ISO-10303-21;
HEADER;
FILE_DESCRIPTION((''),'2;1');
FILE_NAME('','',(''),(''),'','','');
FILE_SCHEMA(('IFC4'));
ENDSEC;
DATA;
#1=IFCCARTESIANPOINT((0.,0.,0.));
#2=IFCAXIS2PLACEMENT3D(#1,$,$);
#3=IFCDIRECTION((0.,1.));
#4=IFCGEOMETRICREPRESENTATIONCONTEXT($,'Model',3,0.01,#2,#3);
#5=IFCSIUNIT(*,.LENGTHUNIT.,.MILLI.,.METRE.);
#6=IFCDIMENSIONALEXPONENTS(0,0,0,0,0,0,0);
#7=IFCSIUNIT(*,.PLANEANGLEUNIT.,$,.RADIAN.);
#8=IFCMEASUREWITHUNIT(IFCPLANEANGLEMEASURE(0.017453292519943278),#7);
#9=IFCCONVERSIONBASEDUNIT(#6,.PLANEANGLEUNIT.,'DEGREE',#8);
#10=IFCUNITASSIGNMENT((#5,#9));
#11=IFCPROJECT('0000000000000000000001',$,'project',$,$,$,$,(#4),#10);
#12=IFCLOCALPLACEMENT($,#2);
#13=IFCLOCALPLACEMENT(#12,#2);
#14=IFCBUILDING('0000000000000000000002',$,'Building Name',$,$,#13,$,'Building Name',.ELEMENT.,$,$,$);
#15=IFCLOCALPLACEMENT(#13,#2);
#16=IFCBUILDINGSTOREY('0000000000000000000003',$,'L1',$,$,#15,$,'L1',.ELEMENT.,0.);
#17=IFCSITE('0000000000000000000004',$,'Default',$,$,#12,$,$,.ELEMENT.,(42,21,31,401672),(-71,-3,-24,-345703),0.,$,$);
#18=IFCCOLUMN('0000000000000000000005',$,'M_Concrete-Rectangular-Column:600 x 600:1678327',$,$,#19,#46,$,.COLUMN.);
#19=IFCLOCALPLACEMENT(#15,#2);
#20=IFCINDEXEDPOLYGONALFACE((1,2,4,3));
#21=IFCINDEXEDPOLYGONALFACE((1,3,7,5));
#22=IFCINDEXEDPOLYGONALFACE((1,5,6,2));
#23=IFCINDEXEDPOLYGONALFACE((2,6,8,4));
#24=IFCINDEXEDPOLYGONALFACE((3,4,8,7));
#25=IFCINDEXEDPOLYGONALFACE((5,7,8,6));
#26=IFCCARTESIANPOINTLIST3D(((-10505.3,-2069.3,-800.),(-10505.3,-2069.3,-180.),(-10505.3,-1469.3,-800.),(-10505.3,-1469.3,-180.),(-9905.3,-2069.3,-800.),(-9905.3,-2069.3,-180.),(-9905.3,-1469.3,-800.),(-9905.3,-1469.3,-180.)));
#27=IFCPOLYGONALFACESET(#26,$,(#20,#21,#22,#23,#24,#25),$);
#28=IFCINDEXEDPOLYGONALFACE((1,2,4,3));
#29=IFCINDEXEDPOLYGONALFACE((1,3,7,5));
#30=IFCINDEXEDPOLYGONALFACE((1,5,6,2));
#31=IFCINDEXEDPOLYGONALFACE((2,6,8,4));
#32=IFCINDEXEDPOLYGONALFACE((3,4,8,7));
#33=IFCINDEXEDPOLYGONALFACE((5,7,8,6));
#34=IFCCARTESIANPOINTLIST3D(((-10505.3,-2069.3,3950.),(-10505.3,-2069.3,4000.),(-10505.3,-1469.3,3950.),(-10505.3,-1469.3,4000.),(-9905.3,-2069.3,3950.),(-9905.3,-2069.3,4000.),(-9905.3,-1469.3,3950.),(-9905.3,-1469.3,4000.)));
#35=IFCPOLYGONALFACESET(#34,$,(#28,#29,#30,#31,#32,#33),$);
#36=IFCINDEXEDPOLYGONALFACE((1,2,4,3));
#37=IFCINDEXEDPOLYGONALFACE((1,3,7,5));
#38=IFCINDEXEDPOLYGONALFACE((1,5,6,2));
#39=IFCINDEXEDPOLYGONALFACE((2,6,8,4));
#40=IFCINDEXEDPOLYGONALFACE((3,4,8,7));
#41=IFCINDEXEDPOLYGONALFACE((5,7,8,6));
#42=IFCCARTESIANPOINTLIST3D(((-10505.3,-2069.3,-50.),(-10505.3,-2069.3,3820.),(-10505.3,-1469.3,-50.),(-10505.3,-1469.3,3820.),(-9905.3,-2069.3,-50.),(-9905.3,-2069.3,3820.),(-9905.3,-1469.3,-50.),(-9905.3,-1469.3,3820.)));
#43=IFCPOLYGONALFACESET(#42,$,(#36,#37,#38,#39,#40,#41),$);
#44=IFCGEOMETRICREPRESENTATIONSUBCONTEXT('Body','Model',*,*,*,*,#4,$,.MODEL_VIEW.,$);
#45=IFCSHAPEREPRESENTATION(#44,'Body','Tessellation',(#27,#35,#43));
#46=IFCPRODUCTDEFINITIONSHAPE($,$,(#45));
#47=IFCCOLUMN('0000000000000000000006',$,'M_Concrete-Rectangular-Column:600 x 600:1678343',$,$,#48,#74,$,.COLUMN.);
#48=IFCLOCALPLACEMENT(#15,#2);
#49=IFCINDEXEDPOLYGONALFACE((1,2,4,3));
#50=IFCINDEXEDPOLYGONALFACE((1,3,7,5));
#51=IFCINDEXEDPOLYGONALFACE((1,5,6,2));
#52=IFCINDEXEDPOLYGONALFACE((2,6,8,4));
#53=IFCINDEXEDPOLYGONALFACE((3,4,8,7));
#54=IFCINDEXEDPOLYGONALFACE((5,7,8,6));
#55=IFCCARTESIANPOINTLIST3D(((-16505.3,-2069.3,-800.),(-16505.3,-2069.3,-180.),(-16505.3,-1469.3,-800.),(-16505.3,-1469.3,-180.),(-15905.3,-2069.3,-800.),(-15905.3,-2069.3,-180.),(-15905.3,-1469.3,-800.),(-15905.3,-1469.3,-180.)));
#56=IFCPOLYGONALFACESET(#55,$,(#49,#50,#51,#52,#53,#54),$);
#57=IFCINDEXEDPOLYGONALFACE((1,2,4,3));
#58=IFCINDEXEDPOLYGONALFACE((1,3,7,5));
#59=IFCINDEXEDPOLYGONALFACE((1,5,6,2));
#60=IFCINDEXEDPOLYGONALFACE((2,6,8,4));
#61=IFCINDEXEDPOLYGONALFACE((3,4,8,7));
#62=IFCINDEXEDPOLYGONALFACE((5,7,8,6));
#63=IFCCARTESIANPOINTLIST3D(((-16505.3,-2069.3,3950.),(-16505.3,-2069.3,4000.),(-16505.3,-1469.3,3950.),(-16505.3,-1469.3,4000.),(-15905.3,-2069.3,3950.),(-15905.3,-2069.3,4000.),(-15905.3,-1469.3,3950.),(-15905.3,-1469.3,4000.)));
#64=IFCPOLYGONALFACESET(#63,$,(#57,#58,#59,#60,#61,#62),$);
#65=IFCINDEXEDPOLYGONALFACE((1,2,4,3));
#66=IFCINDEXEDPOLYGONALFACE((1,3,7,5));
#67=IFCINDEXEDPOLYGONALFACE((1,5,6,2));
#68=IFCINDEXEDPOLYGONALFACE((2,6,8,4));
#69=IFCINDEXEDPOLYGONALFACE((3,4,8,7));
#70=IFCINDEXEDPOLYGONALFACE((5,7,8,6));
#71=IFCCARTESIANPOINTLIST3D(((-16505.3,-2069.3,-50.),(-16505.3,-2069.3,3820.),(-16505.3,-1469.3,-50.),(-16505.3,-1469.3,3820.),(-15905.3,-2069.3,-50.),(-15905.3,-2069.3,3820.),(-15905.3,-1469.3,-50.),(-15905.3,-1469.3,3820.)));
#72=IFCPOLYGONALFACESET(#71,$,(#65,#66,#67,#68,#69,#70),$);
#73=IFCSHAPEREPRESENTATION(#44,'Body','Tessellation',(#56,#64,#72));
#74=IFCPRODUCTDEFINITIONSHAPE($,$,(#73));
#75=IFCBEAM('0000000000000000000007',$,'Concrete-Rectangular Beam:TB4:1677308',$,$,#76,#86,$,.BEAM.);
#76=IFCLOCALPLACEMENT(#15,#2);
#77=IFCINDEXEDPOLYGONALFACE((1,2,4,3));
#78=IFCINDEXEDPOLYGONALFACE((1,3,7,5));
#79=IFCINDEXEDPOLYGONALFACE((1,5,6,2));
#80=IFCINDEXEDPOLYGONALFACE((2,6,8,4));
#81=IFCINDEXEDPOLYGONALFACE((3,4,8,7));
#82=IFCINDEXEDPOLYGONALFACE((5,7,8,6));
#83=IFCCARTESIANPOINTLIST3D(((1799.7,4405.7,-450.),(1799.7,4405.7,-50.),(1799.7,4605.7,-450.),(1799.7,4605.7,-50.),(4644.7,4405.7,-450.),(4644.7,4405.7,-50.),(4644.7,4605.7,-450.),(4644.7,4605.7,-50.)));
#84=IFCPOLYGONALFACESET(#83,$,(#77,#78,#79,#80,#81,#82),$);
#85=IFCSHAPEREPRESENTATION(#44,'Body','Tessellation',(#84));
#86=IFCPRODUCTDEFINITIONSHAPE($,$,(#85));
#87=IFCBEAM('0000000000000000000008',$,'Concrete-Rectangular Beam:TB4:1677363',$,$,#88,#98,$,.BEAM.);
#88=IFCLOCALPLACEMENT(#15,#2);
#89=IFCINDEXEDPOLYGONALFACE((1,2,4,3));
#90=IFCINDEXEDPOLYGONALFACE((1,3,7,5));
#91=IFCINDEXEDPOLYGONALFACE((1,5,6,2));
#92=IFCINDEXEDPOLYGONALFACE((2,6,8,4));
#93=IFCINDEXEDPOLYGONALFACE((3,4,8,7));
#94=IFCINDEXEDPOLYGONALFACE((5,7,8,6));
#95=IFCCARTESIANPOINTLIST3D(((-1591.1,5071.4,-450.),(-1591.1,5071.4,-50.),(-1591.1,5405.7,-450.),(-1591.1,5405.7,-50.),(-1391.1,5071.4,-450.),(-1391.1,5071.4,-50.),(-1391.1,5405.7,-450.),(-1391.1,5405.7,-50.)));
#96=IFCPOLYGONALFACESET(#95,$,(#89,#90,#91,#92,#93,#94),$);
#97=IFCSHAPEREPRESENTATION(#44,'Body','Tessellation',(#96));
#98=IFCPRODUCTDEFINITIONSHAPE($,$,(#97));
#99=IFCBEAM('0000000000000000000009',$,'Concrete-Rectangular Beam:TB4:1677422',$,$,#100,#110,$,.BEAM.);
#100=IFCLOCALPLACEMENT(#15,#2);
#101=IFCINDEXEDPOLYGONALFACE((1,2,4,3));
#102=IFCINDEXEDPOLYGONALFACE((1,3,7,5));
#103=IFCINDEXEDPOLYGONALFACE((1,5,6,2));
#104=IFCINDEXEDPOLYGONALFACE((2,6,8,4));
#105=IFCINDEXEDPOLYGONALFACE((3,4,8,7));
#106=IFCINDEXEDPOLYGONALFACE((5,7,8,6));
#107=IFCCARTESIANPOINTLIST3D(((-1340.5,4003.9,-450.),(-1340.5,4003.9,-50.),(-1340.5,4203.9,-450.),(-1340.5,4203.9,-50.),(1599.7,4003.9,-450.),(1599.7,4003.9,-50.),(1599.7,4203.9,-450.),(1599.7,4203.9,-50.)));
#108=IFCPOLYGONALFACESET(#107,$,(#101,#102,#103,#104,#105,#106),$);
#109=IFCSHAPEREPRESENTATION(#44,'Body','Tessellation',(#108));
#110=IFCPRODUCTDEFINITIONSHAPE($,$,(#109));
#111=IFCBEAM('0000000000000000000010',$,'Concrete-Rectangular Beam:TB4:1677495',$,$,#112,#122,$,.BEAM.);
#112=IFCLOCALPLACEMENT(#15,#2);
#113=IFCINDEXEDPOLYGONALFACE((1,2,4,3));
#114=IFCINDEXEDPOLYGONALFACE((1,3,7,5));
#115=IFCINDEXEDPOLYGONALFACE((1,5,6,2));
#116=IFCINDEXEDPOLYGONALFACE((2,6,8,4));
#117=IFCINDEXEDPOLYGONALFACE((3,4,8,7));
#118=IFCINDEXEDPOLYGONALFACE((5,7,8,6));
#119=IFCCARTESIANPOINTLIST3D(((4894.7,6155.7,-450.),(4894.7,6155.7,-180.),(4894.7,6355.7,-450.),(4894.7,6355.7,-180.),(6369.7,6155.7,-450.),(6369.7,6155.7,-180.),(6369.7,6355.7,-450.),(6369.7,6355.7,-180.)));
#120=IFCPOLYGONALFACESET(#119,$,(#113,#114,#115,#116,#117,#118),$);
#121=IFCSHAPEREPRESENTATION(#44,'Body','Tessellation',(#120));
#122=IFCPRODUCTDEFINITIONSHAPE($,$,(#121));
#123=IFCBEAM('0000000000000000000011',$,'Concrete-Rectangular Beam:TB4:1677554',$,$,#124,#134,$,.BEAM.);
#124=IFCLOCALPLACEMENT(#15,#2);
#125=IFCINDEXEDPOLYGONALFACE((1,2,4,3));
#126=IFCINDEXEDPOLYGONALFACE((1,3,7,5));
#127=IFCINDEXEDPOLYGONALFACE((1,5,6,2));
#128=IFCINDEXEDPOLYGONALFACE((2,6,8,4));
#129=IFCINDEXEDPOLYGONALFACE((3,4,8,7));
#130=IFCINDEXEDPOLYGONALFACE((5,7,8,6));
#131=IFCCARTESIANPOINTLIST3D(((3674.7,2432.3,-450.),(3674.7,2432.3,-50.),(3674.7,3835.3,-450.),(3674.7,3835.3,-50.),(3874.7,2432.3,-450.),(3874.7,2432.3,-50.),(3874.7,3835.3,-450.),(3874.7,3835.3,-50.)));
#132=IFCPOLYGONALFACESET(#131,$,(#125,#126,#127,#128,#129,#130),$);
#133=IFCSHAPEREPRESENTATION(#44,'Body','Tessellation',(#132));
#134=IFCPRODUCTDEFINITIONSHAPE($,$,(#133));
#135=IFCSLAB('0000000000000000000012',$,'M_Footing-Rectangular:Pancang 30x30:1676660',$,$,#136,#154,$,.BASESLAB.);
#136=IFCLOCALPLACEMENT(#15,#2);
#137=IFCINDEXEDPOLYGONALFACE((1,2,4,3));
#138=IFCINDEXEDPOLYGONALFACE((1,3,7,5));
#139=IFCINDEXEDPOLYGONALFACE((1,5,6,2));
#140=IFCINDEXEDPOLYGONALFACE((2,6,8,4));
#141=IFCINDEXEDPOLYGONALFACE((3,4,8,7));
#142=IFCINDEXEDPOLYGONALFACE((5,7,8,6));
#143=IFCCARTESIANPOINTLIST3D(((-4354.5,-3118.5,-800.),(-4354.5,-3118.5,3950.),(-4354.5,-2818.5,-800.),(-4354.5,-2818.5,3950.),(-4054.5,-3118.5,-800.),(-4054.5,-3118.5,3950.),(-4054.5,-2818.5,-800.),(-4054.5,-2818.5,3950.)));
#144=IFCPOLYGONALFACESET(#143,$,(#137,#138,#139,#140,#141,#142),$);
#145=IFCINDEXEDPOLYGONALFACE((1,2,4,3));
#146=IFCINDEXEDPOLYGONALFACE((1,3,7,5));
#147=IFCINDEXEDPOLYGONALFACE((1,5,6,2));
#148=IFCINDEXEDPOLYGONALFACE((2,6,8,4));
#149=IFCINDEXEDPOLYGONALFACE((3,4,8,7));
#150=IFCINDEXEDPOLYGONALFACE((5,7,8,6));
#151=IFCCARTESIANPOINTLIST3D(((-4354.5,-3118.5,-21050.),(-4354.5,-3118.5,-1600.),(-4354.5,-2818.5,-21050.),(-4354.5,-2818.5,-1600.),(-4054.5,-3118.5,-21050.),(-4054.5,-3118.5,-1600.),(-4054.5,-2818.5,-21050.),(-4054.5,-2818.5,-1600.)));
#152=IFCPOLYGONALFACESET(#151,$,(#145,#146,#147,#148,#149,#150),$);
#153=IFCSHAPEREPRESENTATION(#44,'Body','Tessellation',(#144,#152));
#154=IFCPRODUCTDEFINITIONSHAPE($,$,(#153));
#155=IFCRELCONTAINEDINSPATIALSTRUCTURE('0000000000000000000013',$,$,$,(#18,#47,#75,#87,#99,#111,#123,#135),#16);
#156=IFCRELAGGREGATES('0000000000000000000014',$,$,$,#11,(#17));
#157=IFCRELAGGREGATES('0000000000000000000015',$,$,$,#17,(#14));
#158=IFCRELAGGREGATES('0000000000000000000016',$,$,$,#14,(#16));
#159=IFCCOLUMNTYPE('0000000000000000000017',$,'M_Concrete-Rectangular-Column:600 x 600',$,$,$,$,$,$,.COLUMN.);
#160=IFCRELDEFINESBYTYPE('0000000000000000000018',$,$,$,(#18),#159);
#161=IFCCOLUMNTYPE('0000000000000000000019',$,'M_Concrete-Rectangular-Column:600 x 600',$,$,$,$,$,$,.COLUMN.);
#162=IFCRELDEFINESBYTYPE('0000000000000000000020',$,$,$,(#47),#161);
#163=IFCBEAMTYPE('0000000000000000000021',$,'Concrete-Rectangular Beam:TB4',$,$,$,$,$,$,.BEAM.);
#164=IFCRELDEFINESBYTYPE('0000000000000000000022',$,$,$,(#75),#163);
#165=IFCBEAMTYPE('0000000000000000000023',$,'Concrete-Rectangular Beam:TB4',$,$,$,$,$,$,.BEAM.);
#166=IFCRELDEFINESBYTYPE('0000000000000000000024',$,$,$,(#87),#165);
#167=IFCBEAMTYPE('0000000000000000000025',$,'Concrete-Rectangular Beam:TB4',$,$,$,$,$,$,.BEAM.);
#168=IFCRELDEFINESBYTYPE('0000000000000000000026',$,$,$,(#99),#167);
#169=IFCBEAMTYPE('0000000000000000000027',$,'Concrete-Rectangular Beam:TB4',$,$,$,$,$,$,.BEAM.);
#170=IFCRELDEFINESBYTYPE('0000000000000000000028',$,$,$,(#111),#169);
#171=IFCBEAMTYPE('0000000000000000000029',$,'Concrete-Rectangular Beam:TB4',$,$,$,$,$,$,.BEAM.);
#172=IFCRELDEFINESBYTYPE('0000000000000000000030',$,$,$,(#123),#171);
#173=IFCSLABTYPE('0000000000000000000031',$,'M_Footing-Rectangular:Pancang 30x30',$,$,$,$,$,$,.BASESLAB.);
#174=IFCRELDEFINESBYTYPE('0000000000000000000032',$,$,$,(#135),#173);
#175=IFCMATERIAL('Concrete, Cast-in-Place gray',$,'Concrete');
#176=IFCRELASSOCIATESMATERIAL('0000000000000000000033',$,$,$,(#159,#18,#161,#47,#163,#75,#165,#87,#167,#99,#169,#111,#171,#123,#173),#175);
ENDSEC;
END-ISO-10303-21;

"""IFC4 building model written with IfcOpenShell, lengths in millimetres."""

from ifc_helpers import new_model, entity, si_unit, converted_unit, direction, frame, origin, place, context, subcontext, project, spatial, indexed_curve, outline, extrude, source, transform, mapped, material, type_object, type_shapes, element, save


model = new_model("IFC4")

# Units and contexts
model_context = context("Model", 3, precision=0.01, world=origin(), true_north=direction((0.0, 1.0)))
body_context = subcontext(model_context, "Body", "Model", "MODEL_VIEW")
ifc_project = project(units=[si_unit("LENGTHUNIT", "METRE", prefix="MILLI"), converted_unit("PLANEANGLEUNIT", "DEGREE", entity("IfcPlaneAngleMeasure", 0.017453292519943278), si_unit("PLANEANGLEUNIT", "RADIAN"), dimensions=[0, 0, 0, 0, 0, 0, 0])], contexts=[model_context])

# Site, building, storey
site_placement = place(None, origin())
site = spatial("IfcSite", under=ifc_project, at=site_placement, Name="Default", CompositionType="ELEMENT", RefLatitude=(42, 21, 31, 401672), RefLongitude=(-71, -3, -24, -345703), RefElevation=0.0)
building_placement = place(site_placement, origin())
building = spatial("IfcBuilding", under=site, at=building_placement, Name="Building Name", LongName="Building Name", CompositionType="ELEMENT")
storey_placement = place(building_placement, origin())
storey = spatial("IfcBuildingStorey", under=building, at=storey_placement, Name="L1", LongName="L1", CompositionType="ELEMENT", Elevation=0.0)

# Columns
ifc_material = material(Name="Concrete, Cast-in-Place gray", Category="Concrete")
column_type_1 = type_object("IfcColumnType", Name="M_Concrete-Rectangular-Column:600 x 600", PredefinedType="COLUMN", material=ifc_material)
shared_shape_1 = source(origin(), body_context, "Body", "SweptSolid", [
    extrude(outline(indexed_curve([(-300.0, -300.0), (300.0, -300.0), (300.0, 300.0), (-300.0, 300.0), (-300.0, -300.0)], self_intersect=False)), frame((-10205.3, -1769.3, -800.0), z_axis=(0.0, 0.0, 1.0), x_axis=(-1.0, 0.0, 0.0)), (0.0, 0.0, 1.0), 620.0),
    extrude(outline(indexed_curve([(-300.0, -300.0), (300.0, -300.0), (300.0, 300.0), (-300.0, 300.0), (-300.0, -300.0)], self_intersect=False)), frame((-10205.3, -1769.3, 3950.0)), (0.0, 0.0, 1.0), 50.0),
    extrude(outline(indexed_curve([(-300.0, -300.0), (300.0, -300.0), (300.0, 300.0), (-300.0, 300.0), (-300.0, -300.0)], self_intersect=False)), frame((-10205.3, -1769.3, -50.0), z_axis=(0.0, 0.0, 1.0), x_axis=(0.0, 1.0, 0.0)), (0.0, 0.0, 1.0), 3870.0),
])
type_shapes(column_type_1, [shared_shape_1])
column_1_placement = place(storey_placement, origin())
element("IfcColumn", 1, at=column_1_placement, inside=storey, type_object=column_type_1, material=ifc_material, Name="M_Concrete-Rectangular-Column:600 x 600:1678327", PredefinedType="COLUMN", context=body_context, shape_type="MappedRepresentation", body=[
    mapped(shared_shape_1, transform((0.0, 0.0, 0.0), scale=1.0)),
])
column_type_2 = type_object("IfcColumnType", Name="M_Concrete-Rectangular-Column:600 x 600", PredefinedType="COLUMN", material=ifc_material)
shared_shape_2 = source(origin(), body_context, "Body", "SweptSolid", [
    extrude(outline(indexed_curve([(-300.0, -300.0), (300.0, -300.0), (300.0, 300.0), (-300.0, 300.0), (-300.0, -300.0)], self_intersect=False)), frame((-16205.3, -1769.3, -800.0), z_axis=(0.0, 0.0, 1.0), x_axis=(-1.0, 0.0, 0.0)), (0.0, 0.0, 1.0), 620.0),
    extrude(outline(indexed_curve([(-300.0, -300.0), (300.0, -300.0), (300.0, 300.0), (-300.0, 300.0), (-300.0, -300.0)], self_intersect=False)), frame((-16205.3, -1769.3, 3950.0), z_axis=(0.0, 0.0, 1.0), x_axis=(0.0, 1.0, 0.0)), (0.0, 0.0, 1.0), 50.0),
    extrude(outline(indexed_curve([(-300.0, -300.0), (300.0, -300.0), (300.0, 300.0), (-300.0, 300.0), (-300.0, -300.0)], self_intersect=False)), frame((-16205.3, -1769.3, -50.0), z_axis=(0.0, 0.0, 1.0), x_axis=(0.0, 1.0, 0.0)), (0.0, 0.0, 1.0), 3870.0),
])
type_shapes(column_type_2, [shared_shape_2])
column_2_placement = place(storey_placement, origin())
element("IfcColumn", 2, at=column_2_placement, inside=storey, type_object=column_type_2, material=ifc_material, Name="M_Concrete-Rectangular-Column:600 x 600:1678343", PredefinedType="COLUMN", context=body_context, shape_type="MappedRepresentation", body=[
    mapped(shared_shape_2, transform((0.0, 0.0, 0.0), scale=1.0)),
])

# Beams
beam_type_1 = type_object("IfcBeamType", Name="Concrete-Rectangular Beam:TB4", PredefinedType="BEAM", material=ifc_material)
shared_shape_3 = source(origin(), body_context, "Body", "SweptSolid", [
    extrude(outline(indexed_curve([(-200.0, -100.0), (200.0, -100.0), (200.0, 100.0), (-200.0, 100.0), (-200.0, -100.0)], self_intersect=False)), frame((1799.7, 4505.7, -250.0), z_axis=(1.0, 0.0, 0.0), x_axis=(0.0, 0.0, -1.0)), (0.0, 0.0, 1.0), 2845.0),
])
type_shapes(beam_type_1, [shared_shape_3])
beam_1_placement = place(storey_placement, origin())
element("IfcBeam", 3, at=beam_1_placement, inside=storey, type_object=beam_type_1, material=ifc_material, Name="Concrete-Rectangular Beam:TB4:1677308", PredefinedType="BEAM", context=body_context, shape_type="MappedRepresentation", body=[
    mapped(shared_shape_3, transform((0.0, 0.0, 0.0), scale=1.0)),
])
beam_type_2 = type_object("IfcBeamType", Name="Concrete-Rectangular Beam:TB4", PredefinedType="BEAM", material=ifc_material)
shared_shape_4 = source(origin(), body_context, "Body", "SweptSolid", [
    extrude(outline(indexed_curve([(-100.0, -200.0), (100.0, -200.0), (100.0, 200.0), (-100.0, 200.0), (-100.0, -200.0)], self_intersect=False)), frame((-1491.1, 5405.7, -250.0), z_axis=(0.0, -1.0, 0.0), x_axis=(-1.0, 0.0, 0.0)), (0.0, 0.0, 1.0), 334.2),
])
type_shapes(beam_type_2, [shared_shape_4])
beam_2_placement = place(storey_placement, origin())
element("IfcBeam", 4, at=beam_2_placement, inside=storey, type_object=beam_type_2, material=ifc_material, Name="Concrete-Rectangular Beam:TB4:1677363", PredefinedType="BEAM", context=body_context, shape_type="MappedRepresentation", body=[
    mapped(shared_shape_4, transform((0.0, 0.0, 0.0), scale=1.0)),
])
beam_type_3 = type_object("IfcBeamType", Name="Concrete-Rectangular Beam:TB4", PredefinedType="BEAM", material=ifc_material)
shared_shape_5 = source(origin(), body_context, "Body", "SweptSolid", [
    extrude(outline(indexed_curve([(-200.0, -100.0), (200.0, -100.0), (200.0, 100.0), (-200.0, 100.0), (-200.0, -100.0)], self_intersect=False)), frame((-1340.5, 4103.9, -250.0), z_axis=(1.0, 0.0, 0.0), x_axis=(0.0, 0.0, -1.0)), (0.0, 0.0, 1.0), 2940.2),
])
type_shapes(beam_type_3, [shared_shape_5])
beam_3_placement = place(storey_placement, origin())
element("IfcBeam", 5, at=beam_3_placement, inside=storey, type_object=beam_type_3, material=ifc_material, Name="Concrete-Rectangular Beam:TB4:1677422", PredefinedType="BEAM", context=body_context, shape_type="MappedRepresentation", body=[
    mapped(shared_shape_5, transform((0.0, 0.0, 0.0), scale=1.0)),
])
beam_type_4 = type_object("IfcBeamType", Name="Concrete-Rectangular Beam:TB4", PredefinedType="BEAM", material=ifc_material)
shared_shape_6 = source(origin(), body_context, "Body", "SweptSolid", [
    extrude(outline(indexed_curve([(-135.0, -100.0), (135.0, -100.0), (135.0, 100.0), (-135.0, 100.0), (-135.0, -100.0)], self_intersect=False)), frame((4894.7, 6255.7, -315.0), z_axis=(1.0, 0.0, 0.0), x_axis=(0.0, 0.0, -1.0)), (0.0, 0.0, 1.0), 1475.0),
])
type_shapes(beam_type_4, [shared_shape_6])
beam_4_placement = place(storey_placement, origin())
element("IfcBeam", 6, at=beam_4_placement, inside=storey, type_object=beam_type_4, material=ifc_material, Name="Concrete-Rectangular Beam:TB4:1677495", PredefinedType="BEAM", context=body_context, shape_type="MappedRepresentation", body=[
    mapped(shared_shape_6, transform((0.0, 0.0, 0.0), scale=1.0)),
])
beam_type_5 = type_object("IfcBeamType", Name="Concrete-Rectangular Beam:TB4", PredefinedType="BEAM", material=ifc_material)
shared_shape_7 = source(origin(), body_context, "Body", "SweptSolid", [
    extrude(outline(indexed_curve([(-100.0, -200.0), (100.0, -200.0), (100.0, 200.0), (-100.0, 200.0), (-100.0, -200.0)], self_intersect=False)), frame((3774.7, 3835.3, -250.0), z_axis=(0.0, -1.0, 0.0), x_axis=(-1.0, 0.0, 0.0)), (0.0, 0.0, 1.0), 1403.0),
])
type_shapes(beam_type_5, [shared_shape_7])
beam_5_placement = place(storey_placement, origin())
element("IfcBeam", 7, at=beam_5_placement, inside=storey, type_object=beam_type_5, material=ifc_material, Name="Concrete-Rectangular Beam:TB4:1677554", PredefinedType="BEAM", context=body_context, shape_type="MappedRepresentation", body=[
    mapped(shared_shape_7, transform((0.0, 0.0, 0.0), scale=1.0)),
])

# Slab
slab_type = type_object("IfcSlabType", Name="M_Footing-Rectangular:Pancang 30x30", PredefinedType="BASESLAB", material=ifc_material)
slab_placement = place(storey_placement, origin())
element("IfcSlab", 8, at=slab_placement, inside=storey, type_object=slab_type, Name="M_Footing-Rectangular:Pancang 30x30:1676660", PredefinedType="BASESLAB", context=body_context, shape_type="SweptSolid", body=[
    extrude(outline(indexed_curve([(-150.0, -150.0), (150.0, -150.0), (150.0, 150.0), (-150.0, 150.0), (-150.0, -150.0)], self_intersect=False)), frame((-4204.5, -2968.5, -800.0), z_axis=(0.0, 0.0, 1.0), x_axis=(0.0, -1.0, 0.0)), (0.0, 0.0, 1.0), 4750.0),
    extrude(outline(indexed_curve([(-150.0, -150.0), (150.0, -150.0), (150.0, 150.0), (-150.0, 150.0), (-150.0, -150.0)], self_intersect=False)), frame((-4204.5, -2968.5, -21050.0), z_axis=(0.0, 0.0, 1.0), x_axis=(-1.0, 0.0, 0.0)), (0.0, 0.0, 1.0), 19450.0),
])

save(model, "model.ifc")
